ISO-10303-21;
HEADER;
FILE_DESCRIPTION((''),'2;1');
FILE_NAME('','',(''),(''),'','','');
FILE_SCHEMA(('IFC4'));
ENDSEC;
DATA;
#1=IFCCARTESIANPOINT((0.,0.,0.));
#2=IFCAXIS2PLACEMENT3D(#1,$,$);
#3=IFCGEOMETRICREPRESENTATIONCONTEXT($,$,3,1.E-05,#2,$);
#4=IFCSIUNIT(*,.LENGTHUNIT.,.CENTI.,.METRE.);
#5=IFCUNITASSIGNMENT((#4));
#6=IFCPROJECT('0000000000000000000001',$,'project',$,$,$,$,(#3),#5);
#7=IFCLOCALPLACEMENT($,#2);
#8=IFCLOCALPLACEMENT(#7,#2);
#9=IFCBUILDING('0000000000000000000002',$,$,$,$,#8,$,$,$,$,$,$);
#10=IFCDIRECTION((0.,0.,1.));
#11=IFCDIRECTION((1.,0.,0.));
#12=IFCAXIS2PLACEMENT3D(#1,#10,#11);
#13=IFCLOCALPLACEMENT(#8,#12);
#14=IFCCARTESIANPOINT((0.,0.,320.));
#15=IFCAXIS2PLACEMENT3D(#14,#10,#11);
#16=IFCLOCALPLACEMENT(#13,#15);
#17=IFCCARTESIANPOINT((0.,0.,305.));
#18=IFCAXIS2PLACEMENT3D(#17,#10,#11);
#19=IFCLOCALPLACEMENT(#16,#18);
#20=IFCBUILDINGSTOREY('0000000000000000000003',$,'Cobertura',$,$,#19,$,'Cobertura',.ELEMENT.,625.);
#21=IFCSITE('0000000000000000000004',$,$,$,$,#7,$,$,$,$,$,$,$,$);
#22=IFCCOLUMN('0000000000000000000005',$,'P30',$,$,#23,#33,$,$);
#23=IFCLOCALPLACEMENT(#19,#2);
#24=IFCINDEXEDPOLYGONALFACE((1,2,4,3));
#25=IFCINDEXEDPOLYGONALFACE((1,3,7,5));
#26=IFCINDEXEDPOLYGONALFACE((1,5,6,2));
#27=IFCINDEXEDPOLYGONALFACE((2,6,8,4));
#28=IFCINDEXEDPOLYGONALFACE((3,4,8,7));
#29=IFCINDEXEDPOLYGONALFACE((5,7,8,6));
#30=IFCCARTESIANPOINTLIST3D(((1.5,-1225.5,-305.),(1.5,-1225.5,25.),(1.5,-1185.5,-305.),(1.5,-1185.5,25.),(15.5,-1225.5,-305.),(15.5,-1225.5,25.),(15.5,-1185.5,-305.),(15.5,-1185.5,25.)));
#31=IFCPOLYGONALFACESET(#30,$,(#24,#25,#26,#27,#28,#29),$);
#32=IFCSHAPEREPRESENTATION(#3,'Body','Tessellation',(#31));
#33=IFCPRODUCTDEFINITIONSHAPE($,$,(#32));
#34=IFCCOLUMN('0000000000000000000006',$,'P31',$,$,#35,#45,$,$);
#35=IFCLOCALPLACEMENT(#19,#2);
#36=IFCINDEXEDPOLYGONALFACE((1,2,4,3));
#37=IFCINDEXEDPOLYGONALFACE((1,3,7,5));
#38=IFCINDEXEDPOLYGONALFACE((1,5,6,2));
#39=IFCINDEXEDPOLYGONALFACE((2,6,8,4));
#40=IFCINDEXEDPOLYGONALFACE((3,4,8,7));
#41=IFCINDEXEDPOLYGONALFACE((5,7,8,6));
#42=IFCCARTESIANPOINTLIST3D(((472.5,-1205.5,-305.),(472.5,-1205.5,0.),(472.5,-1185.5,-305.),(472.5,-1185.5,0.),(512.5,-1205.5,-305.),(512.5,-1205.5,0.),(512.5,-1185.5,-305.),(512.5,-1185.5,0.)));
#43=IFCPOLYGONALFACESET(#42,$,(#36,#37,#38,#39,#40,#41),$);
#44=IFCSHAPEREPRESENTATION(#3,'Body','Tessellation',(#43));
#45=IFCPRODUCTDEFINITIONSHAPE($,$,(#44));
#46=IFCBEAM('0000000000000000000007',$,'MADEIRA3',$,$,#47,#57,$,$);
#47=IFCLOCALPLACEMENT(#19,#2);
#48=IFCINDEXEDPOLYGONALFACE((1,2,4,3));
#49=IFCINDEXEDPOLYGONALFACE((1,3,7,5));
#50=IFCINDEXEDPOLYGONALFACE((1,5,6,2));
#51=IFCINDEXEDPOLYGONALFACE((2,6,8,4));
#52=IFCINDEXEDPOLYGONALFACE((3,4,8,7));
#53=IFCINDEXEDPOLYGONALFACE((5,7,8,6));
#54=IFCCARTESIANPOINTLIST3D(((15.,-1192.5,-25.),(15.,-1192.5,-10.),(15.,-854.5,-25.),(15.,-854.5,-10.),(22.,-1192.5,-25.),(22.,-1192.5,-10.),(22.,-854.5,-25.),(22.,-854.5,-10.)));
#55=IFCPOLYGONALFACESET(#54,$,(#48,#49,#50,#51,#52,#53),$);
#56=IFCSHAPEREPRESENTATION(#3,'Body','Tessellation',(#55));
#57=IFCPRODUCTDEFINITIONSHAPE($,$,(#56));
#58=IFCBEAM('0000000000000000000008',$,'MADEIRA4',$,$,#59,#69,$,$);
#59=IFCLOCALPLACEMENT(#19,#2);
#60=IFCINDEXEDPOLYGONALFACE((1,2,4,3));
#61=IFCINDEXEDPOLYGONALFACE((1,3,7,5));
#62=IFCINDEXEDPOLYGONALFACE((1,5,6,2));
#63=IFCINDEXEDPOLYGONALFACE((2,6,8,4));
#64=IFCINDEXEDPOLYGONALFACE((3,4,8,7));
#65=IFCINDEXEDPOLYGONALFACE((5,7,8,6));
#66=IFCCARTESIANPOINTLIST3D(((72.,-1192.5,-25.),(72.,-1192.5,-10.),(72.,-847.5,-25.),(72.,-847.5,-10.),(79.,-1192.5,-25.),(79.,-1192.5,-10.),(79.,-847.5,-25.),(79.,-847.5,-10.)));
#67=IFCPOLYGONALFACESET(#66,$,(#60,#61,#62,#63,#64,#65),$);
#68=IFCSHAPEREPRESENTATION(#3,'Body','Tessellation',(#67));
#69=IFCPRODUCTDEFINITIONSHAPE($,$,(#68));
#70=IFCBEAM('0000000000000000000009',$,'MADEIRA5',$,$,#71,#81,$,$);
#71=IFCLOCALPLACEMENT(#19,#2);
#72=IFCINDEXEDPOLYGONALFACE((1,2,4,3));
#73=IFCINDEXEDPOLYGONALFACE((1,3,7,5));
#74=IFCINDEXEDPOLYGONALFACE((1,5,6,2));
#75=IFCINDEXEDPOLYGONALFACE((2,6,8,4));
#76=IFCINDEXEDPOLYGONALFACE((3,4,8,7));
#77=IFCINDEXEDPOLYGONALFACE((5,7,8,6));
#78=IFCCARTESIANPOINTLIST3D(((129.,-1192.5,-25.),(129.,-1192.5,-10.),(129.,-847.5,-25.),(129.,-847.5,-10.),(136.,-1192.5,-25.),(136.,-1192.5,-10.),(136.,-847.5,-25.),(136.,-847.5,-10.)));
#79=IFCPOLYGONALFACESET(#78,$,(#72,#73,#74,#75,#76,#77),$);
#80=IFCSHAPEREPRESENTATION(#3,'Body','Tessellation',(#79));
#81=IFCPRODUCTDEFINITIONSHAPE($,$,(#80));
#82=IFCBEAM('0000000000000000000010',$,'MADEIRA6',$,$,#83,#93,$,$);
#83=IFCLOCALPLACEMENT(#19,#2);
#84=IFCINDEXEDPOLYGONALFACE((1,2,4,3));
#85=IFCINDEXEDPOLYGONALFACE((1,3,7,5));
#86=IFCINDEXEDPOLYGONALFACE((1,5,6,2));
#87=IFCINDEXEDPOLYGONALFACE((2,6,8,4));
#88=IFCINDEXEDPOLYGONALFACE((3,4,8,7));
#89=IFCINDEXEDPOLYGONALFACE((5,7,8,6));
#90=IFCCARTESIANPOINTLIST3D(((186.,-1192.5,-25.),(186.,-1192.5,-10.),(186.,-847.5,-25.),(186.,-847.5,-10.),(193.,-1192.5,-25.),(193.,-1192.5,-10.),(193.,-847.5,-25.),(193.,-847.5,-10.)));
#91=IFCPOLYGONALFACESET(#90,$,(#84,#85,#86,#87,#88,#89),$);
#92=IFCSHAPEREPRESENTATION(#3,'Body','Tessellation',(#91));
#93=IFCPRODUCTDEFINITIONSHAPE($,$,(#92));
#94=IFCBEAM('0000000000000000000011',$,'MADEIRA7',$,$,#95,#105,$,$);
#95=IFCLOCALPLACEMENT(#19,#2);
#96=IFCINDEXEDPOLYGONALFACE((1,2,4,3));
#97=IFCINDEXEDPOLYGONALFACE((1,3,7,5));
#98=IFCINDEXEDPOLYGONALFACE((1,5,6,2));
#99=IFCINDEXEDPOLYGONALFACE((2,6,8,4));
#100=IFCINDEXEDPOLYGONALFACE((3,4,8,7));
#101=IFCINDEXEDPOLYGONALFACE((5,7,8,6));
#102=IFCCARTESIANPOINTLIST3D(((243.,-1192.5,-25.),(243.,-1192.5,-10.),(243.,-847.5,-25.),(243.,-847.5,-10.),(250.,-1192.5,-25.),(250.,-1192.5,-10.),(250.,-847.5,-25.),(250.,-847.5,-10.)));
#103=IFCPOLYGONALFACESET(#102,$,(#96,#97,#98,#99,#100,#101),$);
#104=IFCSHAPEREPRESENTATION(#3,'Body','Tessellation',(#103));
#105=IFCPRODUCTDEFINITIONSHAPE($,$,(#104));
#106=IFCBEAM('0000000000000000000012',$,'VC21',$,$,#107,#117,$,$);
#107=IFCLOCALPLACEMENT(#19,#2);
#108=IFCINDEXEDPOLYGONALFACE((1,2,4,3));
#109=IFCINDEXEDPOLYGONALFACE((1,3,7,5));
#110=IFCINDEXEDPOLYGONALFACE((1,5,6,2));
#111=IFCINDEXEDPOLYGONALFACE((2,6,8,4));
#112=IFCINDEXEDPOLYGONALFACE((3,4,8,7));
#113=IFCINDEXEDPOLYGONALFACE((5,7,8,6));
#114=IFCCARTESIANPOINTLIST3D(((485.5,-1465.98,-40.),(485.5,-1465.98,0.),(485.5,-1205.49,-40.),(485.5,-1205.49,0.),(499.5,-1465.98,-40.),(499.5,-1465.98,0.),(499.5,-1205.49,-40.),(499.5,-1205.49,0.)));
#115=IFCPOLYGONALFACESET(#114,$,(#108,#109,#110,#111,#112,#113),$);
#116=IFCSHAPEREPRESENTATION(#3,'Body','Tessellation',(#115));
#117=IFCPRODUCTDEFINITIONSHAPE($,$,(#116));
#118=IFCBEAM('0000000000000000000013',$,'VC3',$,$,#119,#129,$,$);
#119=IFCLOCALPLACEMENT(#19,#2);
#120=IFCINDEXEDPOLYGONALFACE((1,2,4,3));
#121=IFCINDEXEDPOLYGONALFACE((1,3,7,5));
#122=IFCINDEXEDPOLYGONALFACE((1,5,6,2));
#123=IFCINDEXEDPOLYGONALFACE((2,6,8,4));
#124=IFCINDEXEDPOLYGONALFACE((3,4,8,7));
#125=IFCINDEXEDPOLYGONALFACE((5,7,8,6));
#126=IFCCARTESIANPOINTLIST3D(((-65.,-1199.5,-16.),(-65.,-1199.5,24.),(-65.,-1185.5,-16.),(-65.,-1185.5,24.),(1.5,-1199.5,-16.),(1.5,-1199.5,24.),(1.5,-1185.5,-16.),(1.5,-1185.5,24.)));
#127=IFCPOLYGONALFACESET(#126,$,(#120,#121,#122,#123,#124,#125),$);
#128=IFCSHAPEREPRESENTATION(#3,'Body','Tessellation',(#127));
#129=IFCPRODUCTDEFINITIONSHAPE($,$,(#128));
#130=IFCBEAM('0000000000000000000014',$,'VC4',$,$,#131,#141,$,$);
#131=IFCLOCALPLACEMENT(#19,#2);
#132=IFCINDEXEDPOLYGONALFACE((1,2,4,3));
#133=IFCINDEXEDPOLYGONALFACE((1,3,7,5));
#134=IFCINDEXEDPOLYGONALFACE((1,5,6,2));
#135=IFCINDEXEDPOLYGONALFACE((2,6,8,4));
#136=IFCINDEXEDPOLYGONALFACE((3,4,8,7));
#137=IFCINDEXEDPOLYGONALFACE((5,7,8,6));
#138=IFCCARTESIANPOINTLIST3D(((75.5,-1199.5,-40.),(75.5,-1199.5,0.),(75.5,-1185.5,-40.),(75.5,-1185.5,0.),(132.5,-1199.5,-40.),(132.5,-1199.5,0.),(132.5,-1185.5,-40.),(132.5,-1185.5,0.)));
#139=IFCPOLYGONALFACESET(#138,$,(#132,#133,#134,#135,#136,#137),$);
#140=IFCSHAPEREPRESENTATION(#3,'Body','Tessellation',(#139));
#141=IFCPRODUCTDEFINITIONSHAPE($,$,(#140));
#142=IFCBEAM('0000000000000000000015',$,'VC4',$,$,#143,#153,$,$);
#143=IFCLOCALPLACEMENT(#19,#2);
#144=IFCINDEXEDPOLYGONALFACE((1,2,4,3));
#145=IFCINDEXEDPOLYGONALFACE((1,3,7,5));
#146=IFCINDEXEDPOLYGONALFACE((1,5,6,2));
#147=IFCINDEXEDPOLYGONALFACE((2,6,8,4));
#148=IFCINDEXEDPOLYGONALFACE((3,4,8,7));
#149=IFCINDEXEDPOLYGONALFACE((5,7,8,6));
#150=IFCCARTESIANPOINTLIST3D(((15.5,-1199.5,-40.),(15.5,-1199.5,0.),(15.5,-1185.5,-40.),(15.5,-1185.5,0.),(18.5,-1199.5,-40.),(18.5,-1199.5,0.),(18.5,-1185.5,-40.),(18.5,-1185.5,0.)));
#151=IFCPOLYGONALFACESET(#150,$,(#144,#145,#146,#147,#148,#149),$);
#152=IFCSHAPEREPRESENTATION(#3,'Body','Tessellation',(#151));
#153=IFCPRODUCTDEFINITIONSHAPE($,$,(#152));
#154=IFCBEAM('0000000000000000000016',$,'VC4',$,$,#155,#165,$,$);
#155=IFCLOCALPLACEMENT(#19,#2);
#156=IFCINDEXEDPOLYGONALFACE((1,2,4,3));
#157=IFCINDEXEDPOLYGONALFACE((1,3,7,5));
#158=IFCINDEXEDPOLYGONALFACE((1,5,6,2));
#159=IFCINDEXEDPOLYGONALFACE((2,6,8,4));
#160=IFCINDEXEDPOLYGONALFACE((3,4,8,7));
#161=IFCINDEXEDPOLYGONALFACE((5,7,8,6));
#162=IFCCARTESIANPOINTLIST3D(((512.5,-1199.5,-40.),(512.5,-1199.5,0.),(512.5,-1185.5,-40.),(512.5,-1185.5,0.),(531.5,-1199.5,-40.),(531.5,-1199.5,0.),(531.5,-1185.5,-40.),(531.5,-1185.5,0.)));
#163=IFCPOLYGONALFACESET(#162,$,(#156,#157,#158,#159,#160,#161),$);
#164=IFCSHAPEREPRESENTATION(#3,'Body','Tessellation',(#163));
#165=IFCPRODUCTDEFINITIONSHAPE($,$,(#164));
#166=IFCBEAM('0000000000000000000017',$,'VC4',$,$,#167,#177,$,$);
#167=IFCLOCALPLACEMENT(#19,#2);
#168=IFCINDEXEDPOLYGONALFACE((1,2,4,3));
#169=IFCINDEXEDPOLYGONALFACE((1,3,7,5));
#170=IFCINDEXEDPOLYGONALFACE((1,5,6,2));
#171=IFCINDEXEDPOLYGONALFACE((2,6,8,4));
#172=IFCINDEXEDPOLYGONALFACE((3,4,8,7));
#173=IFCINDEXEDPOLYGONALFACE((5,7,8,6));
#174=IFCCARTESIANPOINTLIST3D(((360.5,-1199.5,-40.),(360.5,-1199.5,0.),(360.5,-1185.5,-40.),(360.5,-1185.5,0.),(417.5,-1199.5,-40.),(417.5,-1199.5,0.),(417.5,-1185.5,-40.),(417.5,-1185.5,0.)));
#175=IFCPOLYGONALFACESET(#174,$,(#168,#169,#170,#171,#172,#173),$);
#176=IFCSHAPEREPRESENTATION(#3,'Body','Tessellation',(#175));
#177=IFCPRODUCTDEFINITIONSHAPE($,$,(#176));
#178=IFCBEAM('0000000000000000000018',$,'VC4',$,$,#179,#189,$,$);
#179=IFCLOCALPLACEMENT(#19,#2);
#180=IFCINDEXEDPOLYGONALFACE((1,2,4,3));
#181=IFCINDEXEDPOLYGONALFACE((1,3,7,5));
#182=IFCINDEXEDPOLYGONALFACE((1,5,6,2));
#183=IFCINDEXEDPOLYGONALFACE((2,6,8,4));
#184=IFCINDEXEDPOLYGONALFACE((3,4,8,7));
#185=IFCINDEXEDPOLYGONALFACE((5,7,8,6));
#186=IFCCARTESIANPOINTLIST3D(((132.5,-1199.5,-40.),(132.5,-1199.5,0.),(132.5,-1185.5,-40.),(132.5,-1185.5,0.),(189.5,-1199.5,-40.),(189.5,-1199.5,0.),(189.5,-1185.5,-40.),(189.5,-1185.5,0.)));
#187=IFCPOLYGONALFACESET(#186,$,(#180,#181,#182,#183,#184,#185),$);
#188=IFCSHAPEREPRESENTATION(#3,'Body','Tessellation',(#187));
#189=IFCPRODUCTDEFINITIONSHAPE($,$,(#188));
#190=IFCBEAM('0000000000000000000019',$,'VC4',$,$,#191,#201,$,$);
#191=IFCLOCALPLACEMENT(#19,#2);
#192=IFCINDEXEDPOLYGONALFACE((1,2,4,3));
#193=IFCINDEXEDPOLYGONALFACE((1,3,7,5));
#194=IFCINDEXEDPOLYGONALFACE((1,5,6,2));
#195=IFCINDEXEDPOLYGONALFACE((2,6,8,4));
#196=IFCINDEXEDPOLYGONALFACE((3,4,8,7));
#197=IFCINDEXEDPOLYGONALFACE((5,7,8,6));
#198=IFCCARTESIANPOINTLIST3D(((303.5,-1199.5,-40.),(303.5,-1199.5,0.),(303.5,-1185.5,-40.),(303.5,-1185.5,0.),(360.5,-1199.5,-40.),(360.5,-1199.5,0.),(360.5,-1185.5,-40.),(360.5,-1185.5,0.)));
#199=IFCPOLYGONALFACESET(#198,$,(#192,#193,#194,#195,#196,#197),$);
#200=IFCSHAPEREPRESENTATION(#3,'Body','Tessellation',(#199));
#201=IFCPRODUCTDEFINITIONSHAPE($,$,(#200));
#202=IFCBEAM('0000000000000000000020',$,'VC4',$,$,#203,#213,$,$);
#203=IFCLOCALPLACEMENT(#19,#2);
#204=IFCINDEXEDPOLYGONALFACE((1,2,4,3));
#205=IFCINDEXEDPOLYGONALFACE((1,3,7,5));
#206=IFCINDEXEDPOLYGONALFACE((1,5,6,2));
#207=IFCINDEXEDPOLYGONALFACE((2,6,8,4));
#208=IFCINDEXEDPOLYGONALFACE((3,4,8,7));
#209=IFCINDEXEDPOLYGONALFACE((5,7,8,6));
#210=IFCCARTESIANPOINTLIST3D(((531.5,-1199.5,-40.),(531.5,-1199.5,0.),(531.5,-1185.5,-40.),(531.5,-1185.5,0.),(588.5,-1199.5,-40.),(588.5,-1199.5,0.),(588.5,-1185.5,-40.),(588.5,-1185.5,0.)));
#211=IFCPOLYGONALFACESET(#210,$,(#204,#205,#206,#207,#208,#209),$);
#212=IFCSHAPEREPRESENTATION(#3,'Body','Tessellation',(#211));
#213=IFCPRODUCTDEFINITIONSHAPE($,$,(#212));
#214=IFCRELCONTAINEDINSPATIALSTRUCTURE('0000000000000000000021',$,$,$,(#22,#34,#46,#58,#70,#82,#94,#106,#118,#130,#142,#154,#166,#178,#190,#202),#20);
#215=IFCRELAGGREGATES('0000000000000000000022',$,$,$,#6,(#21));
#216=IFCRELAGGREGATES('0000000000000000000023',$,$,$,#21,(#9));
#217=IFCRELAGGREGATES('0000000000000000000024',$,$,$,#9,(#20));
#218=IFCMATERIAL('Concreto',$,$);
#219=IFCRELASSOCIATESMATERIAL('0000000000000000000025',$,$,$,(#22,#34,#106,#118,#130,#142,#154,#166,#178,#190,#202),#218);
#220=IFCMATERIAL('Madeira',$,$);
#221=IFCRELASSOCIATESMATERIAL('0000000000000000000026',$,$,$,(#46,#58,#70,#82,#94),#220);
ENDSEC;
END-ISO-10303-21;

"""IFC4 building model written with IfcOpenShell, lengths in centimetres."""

from ifc_helpers import new_model, si_unit, frame, origin, origin_with_axes, place, context, project, spatial, polyline, outline, extrude, material, element, save


model = new_model("IFC4")

# Units and contexts
context_of_model = context(None, 3, precision=1e-05, world=origin())
ifc_project = project(units=[si_unit("LENGTHUNIT", "METRE", prefix="CENTI")], contexts=[context_of_model])

# Site, building, storey
site_placement = place(None, origin())
site = spatial("IfcSite", under=ifc_project, at=site_placement)
building_placement = place(site_placement, origin())
building = spatial("IfcBuilding", under=site, at=building_placement)
placement_1 = place(building_placement, origin_with_axes())
placement_2 = place(placement_1, frame((0.0, 0.0, 320.0), z_axis=(0.0, 0.0, 1.0), x_axis=(1.0, 0.0, 0.0)))
storey_placement = place(placement_2, frame((0.0, 0.0, 305.0), z_axis=(0.0, 0.0, 1.0), x_axis=(1.0, 0.0, 0.0)))
storey = spatial("IfcBuildingStorey", under=building, at=storey_placement, Name="Cobertura", LongName="Cobertura", CompositionType="ELEMENT", Elevation=625.0)

# Columns
ifc_material_1 = material(Name="Concreto")
column_1_placement = place(storey_placement, frame((8.5, -1205.5, 25.0), z_axis=(0.0, 0.0, 1.0), x_axis=(1.0, 0.0, 0.0)))
element("IfcColumn", 1, at=column_1_placement, inside=storey, material=ifc_material_1, Name="P30", context=context_of_model, shape_type="SolidModel", body=[
    extrude(outline(polyline([(7.0, 20.0), (-7.0, 20.0), (-7.0, -20.0), (7.0, -20.0), (7.0, 20.0)])), frame((0.0, 0.0, 0.0), z_axis=(0.0, 0.0, 1.0), x_axis=(1.0, 0.0, 0.0)), (0.0, 0.0, -1.0), 330.0),
])
column_2_placement = place(storey_placement, frame((492.5, -1195.5, 0.0), z_axis=(0.0, 0.0, 1.0), x_axis=(1.0, 0.0, 0.0)))
element("IfcColumn", 2, at=column_2_placement, inside=storey, material=ifc_material_1, Name="P31", context=context_of_model, shape_type="SolidModel", body=[
    extrude(outline(polyline([(-20.0, 10.0), (-20.0, -10.0), (20.0, -10.0), (20.0, 10.0), (-20.0, 10.0)])), origin_with_axes(), (0.0, 0.0, -1.0), 305.0),
])

# Beams
ifc_material_2 = material(Name="Madeira")
beam_1_placement = place(storey_placement, frame((18.5, -1023.5, -10.0), z_axis=(0.0, 0.0, 1.0), x_axis=(1.0, 0.0, 0.0)))
element("IfcBeam", 3, at=beam_1_placement, inside=storey, material=ifc_material_2, Name="MADEIRA3", context=context_of_model, shape_type="SolidModel", body=[
    extrude(outline(polyline([(-3.5, -7.5), (-3.5, 7.5), (3.5, 7.5), (3.5, -7.5), (-3.5, -7.5)])), frame((0.0, -169.0, -7.5), z_axis=(0.0, 1.0, 0.0), x_axis=(1.0, 0.0, 0.0)), (0.0, 0.0, 1.0), 338.0),
])
for number, where, z_axis, x_axis, name in (
    (4, (75.5, -1020.0, -10.0), (0.0, 0.0, 1.0), (1.0, 0.0, 0.0), "MADEIRA4"),
    (5, (132.5, -1020.0, -10.0), (0.0, 0.0, 1.0), (1.0, 0.0, 0.0), "MADEIRA5"),
    (6, (189.5, -1020.0, -10.0), (0.0, 0.0, 1.0), (1.0, 0.0, 0.0), "MADEIRA6"),
    (7, (246.5, -1020.0, -10.0), (0.0, 0.0, 1.0), (1.0, 0.0, 0.0), "MADEIRA7"),
):
    element("IfcBeam", number, at=place(storey_placement, frame(where, z_axis=z_axis, x_axis=x_axis)), inside=storey, material=ifc_material_2, Name=name, context=context_of_model, shape_type="SolidModel", body=[
        extrude(outline(polyline([(-3.5, -7.5), (-3.5, 7.5), (3.5, 7.5), (3.5, -7.5), (-3.5, -7.5)])), frame((0.0, -172.5, -7.5), z_axis=(0.0, 1.0, 0.0), x_axis=(1.0, 0.0, 0.0)), (0.0, 0.0, 1.0), 345.0),
    ])
beam_2_placement = place(storey_placement, frame((492.5, -1335.74, 0.0), z_axis=(0.0, 0.0, 1.0), x_axis=(1.0, 0.0, 0.0)))
element("IfcBeam", 8, at=beam_2_placement, inside=storey, material=ifc_material_1, Name="VC21", context=context_of_model, shape_type="SolidModel", body=[
    extrude(outline(polyline([(-7.0, -20.0), (7.0, -20.0), (7.0, 20.0), (-7.0, 20.0), (-7.0, -20.0)])), frame((0.0, -130.25, -20.0), z_axis=(0.0, 1.0, 0.0), x_axis=(1.0, 0.0, 0.0)), (0.0, 0.0, 1.0), 260.49),
])
beam_3_placement = place(storey_placement, frame((-31.75, -1192.5, 24.0), z_axis=(0.0, 0.0, 1.0), x_axis=(1.0, 0.0, 0.0)))
element("IfcBeam", 9, at=beam_3_placement, inside=storey, material=ifc_material_1, Name="VC3", context=context_of_model, shape_type="SolidModel", body=[
    extrude(outline(polyline([(-7.0, -20.0), (7.0, -20.0), (7.0, 20.0), (-7.0, 20.0), (-7.0, -20.0)])), frame((-33.25, 0.0, -20.0), z_axis=(1.0, 0.0, 0.0), x_axis=(0.0, -1.0, 0.0)), (0.0, 0.0, 1.0), 66.5),
])
beam_4_placement = place(storey_placement, frame((104.0, -1192.5, 0.0), z_axis=(0.0, 0.0, 1.0), x_axis=(1.0, 0.0, 0.0)))
element("IfcBeam", 10, at=beam_4_placement, inside=storey, material=ifc_material_1, Name="VC4", context=context_of_model, shape_type="SolidModel", body=[
    extrude(outline(polyline([(-7.0, -20.0), (7.0, -20.0), (7.0, 20.0), (-7.0, 20.0), (-7.0, -20.0)])), frame((-28.5, 0.0, -20.0), z_axis=(1.0, 0.0, 0.0), x_axis=(0.0, -1.0, 0.0)), (0.0, 0.0, 1.0), 57.0),
])
beam_5_placement = place(storey_placement, frame((17.0, -1192.5, 0.0), z_axis=(0.0, 0.0, 1.0), x_axis=(1.0, 0.0, 0.0)))
element("IfcBeam", 11, at=beam_5_placement, inside=storey, material=ifc_material_1, Name="VC4", context=context_of_model, shape_type="SolidModel", body=[
    extrude(outline(polyline([(-7.0, -20.0), (7.0, -20.0), (7.0, 20.0), (-7.0, 20.0), (-7.0, -20.0)])), frame((-1.5, 0.0, -20.0), z_axis=(1.0, 0.0, 0.0), x_axis=(0.0, -1.0, 0.0)), (0.0, 0.0, 1.0), 3.0),
])
beam_6_placement = place(storey_placement, frame((522.0, -1192.5, 0.0), z_axis=(0.0, 0.0, 1.0), x_axis=(1.0, 0.0, 0.0)))
element("IfcBeam", 12, at=beam_6_placement, inside=storey, material=ifc_material_1, Name="VC4", context=context_of_model, shape_type="SolidModel", body=[
    extrude(outline(polyline([(-7.0, -20.0), (7.0, -20.0), (7.0, 20.0), (-7.0, 20.0), (-7.0, -20.0)])), frame((-9.5, 0.0, -20.0), z_axis=(1.0, 0.0, 0.0), x_axis=(0.0, -1.0, 0.0)), (0.0, 0.0, 1.0), 19.0),
])
for number, where, z_axis, x_axis, name in (
    (13, (389.0, -1192.5, 0.0), (0.0, 0.0, 1.0), (1.0, 0.0, 0.0), "VC4"),
    (14, (161.0, -1192.5, 0.0), (0.0, 0.0, 1.0), (1.0, 0.0, 0.0), "VC4"),
    (15, (332.0, -1192.5, 0.0), (0.0, 0.0, 1.0), (1.0, 0.0, 0.0), "VC4"),
    (16, (560.0, -1192.5, 0.0), (0.0, 0.0, 1.0), (1.0, 0.0, 0.0), "VC4"),
):
    element("IfcBeam", number, at=place(storey_placement, frame(where, z_axis=z_axis, x_axis=x_axis)), inside=storey, material=ifc_material_1, Name=name, context=context_of_model, shape_type="SolidModel", body=[
        extrude(outline(polyline([(-7.0, -20.0), (7.0, -20.0), (7.0, 20.0), (-7.0, 20.0), (-7.0, -20.0)])), frame((-28.5, 0.0, -20.0), z_axis=(1.0, 0.0, 0.0), x_axis=(0.0, -1.0, 0.0)), (0.0, 0.0, 1.0), 57.0),
    ])

save(model, "model.ifc")
